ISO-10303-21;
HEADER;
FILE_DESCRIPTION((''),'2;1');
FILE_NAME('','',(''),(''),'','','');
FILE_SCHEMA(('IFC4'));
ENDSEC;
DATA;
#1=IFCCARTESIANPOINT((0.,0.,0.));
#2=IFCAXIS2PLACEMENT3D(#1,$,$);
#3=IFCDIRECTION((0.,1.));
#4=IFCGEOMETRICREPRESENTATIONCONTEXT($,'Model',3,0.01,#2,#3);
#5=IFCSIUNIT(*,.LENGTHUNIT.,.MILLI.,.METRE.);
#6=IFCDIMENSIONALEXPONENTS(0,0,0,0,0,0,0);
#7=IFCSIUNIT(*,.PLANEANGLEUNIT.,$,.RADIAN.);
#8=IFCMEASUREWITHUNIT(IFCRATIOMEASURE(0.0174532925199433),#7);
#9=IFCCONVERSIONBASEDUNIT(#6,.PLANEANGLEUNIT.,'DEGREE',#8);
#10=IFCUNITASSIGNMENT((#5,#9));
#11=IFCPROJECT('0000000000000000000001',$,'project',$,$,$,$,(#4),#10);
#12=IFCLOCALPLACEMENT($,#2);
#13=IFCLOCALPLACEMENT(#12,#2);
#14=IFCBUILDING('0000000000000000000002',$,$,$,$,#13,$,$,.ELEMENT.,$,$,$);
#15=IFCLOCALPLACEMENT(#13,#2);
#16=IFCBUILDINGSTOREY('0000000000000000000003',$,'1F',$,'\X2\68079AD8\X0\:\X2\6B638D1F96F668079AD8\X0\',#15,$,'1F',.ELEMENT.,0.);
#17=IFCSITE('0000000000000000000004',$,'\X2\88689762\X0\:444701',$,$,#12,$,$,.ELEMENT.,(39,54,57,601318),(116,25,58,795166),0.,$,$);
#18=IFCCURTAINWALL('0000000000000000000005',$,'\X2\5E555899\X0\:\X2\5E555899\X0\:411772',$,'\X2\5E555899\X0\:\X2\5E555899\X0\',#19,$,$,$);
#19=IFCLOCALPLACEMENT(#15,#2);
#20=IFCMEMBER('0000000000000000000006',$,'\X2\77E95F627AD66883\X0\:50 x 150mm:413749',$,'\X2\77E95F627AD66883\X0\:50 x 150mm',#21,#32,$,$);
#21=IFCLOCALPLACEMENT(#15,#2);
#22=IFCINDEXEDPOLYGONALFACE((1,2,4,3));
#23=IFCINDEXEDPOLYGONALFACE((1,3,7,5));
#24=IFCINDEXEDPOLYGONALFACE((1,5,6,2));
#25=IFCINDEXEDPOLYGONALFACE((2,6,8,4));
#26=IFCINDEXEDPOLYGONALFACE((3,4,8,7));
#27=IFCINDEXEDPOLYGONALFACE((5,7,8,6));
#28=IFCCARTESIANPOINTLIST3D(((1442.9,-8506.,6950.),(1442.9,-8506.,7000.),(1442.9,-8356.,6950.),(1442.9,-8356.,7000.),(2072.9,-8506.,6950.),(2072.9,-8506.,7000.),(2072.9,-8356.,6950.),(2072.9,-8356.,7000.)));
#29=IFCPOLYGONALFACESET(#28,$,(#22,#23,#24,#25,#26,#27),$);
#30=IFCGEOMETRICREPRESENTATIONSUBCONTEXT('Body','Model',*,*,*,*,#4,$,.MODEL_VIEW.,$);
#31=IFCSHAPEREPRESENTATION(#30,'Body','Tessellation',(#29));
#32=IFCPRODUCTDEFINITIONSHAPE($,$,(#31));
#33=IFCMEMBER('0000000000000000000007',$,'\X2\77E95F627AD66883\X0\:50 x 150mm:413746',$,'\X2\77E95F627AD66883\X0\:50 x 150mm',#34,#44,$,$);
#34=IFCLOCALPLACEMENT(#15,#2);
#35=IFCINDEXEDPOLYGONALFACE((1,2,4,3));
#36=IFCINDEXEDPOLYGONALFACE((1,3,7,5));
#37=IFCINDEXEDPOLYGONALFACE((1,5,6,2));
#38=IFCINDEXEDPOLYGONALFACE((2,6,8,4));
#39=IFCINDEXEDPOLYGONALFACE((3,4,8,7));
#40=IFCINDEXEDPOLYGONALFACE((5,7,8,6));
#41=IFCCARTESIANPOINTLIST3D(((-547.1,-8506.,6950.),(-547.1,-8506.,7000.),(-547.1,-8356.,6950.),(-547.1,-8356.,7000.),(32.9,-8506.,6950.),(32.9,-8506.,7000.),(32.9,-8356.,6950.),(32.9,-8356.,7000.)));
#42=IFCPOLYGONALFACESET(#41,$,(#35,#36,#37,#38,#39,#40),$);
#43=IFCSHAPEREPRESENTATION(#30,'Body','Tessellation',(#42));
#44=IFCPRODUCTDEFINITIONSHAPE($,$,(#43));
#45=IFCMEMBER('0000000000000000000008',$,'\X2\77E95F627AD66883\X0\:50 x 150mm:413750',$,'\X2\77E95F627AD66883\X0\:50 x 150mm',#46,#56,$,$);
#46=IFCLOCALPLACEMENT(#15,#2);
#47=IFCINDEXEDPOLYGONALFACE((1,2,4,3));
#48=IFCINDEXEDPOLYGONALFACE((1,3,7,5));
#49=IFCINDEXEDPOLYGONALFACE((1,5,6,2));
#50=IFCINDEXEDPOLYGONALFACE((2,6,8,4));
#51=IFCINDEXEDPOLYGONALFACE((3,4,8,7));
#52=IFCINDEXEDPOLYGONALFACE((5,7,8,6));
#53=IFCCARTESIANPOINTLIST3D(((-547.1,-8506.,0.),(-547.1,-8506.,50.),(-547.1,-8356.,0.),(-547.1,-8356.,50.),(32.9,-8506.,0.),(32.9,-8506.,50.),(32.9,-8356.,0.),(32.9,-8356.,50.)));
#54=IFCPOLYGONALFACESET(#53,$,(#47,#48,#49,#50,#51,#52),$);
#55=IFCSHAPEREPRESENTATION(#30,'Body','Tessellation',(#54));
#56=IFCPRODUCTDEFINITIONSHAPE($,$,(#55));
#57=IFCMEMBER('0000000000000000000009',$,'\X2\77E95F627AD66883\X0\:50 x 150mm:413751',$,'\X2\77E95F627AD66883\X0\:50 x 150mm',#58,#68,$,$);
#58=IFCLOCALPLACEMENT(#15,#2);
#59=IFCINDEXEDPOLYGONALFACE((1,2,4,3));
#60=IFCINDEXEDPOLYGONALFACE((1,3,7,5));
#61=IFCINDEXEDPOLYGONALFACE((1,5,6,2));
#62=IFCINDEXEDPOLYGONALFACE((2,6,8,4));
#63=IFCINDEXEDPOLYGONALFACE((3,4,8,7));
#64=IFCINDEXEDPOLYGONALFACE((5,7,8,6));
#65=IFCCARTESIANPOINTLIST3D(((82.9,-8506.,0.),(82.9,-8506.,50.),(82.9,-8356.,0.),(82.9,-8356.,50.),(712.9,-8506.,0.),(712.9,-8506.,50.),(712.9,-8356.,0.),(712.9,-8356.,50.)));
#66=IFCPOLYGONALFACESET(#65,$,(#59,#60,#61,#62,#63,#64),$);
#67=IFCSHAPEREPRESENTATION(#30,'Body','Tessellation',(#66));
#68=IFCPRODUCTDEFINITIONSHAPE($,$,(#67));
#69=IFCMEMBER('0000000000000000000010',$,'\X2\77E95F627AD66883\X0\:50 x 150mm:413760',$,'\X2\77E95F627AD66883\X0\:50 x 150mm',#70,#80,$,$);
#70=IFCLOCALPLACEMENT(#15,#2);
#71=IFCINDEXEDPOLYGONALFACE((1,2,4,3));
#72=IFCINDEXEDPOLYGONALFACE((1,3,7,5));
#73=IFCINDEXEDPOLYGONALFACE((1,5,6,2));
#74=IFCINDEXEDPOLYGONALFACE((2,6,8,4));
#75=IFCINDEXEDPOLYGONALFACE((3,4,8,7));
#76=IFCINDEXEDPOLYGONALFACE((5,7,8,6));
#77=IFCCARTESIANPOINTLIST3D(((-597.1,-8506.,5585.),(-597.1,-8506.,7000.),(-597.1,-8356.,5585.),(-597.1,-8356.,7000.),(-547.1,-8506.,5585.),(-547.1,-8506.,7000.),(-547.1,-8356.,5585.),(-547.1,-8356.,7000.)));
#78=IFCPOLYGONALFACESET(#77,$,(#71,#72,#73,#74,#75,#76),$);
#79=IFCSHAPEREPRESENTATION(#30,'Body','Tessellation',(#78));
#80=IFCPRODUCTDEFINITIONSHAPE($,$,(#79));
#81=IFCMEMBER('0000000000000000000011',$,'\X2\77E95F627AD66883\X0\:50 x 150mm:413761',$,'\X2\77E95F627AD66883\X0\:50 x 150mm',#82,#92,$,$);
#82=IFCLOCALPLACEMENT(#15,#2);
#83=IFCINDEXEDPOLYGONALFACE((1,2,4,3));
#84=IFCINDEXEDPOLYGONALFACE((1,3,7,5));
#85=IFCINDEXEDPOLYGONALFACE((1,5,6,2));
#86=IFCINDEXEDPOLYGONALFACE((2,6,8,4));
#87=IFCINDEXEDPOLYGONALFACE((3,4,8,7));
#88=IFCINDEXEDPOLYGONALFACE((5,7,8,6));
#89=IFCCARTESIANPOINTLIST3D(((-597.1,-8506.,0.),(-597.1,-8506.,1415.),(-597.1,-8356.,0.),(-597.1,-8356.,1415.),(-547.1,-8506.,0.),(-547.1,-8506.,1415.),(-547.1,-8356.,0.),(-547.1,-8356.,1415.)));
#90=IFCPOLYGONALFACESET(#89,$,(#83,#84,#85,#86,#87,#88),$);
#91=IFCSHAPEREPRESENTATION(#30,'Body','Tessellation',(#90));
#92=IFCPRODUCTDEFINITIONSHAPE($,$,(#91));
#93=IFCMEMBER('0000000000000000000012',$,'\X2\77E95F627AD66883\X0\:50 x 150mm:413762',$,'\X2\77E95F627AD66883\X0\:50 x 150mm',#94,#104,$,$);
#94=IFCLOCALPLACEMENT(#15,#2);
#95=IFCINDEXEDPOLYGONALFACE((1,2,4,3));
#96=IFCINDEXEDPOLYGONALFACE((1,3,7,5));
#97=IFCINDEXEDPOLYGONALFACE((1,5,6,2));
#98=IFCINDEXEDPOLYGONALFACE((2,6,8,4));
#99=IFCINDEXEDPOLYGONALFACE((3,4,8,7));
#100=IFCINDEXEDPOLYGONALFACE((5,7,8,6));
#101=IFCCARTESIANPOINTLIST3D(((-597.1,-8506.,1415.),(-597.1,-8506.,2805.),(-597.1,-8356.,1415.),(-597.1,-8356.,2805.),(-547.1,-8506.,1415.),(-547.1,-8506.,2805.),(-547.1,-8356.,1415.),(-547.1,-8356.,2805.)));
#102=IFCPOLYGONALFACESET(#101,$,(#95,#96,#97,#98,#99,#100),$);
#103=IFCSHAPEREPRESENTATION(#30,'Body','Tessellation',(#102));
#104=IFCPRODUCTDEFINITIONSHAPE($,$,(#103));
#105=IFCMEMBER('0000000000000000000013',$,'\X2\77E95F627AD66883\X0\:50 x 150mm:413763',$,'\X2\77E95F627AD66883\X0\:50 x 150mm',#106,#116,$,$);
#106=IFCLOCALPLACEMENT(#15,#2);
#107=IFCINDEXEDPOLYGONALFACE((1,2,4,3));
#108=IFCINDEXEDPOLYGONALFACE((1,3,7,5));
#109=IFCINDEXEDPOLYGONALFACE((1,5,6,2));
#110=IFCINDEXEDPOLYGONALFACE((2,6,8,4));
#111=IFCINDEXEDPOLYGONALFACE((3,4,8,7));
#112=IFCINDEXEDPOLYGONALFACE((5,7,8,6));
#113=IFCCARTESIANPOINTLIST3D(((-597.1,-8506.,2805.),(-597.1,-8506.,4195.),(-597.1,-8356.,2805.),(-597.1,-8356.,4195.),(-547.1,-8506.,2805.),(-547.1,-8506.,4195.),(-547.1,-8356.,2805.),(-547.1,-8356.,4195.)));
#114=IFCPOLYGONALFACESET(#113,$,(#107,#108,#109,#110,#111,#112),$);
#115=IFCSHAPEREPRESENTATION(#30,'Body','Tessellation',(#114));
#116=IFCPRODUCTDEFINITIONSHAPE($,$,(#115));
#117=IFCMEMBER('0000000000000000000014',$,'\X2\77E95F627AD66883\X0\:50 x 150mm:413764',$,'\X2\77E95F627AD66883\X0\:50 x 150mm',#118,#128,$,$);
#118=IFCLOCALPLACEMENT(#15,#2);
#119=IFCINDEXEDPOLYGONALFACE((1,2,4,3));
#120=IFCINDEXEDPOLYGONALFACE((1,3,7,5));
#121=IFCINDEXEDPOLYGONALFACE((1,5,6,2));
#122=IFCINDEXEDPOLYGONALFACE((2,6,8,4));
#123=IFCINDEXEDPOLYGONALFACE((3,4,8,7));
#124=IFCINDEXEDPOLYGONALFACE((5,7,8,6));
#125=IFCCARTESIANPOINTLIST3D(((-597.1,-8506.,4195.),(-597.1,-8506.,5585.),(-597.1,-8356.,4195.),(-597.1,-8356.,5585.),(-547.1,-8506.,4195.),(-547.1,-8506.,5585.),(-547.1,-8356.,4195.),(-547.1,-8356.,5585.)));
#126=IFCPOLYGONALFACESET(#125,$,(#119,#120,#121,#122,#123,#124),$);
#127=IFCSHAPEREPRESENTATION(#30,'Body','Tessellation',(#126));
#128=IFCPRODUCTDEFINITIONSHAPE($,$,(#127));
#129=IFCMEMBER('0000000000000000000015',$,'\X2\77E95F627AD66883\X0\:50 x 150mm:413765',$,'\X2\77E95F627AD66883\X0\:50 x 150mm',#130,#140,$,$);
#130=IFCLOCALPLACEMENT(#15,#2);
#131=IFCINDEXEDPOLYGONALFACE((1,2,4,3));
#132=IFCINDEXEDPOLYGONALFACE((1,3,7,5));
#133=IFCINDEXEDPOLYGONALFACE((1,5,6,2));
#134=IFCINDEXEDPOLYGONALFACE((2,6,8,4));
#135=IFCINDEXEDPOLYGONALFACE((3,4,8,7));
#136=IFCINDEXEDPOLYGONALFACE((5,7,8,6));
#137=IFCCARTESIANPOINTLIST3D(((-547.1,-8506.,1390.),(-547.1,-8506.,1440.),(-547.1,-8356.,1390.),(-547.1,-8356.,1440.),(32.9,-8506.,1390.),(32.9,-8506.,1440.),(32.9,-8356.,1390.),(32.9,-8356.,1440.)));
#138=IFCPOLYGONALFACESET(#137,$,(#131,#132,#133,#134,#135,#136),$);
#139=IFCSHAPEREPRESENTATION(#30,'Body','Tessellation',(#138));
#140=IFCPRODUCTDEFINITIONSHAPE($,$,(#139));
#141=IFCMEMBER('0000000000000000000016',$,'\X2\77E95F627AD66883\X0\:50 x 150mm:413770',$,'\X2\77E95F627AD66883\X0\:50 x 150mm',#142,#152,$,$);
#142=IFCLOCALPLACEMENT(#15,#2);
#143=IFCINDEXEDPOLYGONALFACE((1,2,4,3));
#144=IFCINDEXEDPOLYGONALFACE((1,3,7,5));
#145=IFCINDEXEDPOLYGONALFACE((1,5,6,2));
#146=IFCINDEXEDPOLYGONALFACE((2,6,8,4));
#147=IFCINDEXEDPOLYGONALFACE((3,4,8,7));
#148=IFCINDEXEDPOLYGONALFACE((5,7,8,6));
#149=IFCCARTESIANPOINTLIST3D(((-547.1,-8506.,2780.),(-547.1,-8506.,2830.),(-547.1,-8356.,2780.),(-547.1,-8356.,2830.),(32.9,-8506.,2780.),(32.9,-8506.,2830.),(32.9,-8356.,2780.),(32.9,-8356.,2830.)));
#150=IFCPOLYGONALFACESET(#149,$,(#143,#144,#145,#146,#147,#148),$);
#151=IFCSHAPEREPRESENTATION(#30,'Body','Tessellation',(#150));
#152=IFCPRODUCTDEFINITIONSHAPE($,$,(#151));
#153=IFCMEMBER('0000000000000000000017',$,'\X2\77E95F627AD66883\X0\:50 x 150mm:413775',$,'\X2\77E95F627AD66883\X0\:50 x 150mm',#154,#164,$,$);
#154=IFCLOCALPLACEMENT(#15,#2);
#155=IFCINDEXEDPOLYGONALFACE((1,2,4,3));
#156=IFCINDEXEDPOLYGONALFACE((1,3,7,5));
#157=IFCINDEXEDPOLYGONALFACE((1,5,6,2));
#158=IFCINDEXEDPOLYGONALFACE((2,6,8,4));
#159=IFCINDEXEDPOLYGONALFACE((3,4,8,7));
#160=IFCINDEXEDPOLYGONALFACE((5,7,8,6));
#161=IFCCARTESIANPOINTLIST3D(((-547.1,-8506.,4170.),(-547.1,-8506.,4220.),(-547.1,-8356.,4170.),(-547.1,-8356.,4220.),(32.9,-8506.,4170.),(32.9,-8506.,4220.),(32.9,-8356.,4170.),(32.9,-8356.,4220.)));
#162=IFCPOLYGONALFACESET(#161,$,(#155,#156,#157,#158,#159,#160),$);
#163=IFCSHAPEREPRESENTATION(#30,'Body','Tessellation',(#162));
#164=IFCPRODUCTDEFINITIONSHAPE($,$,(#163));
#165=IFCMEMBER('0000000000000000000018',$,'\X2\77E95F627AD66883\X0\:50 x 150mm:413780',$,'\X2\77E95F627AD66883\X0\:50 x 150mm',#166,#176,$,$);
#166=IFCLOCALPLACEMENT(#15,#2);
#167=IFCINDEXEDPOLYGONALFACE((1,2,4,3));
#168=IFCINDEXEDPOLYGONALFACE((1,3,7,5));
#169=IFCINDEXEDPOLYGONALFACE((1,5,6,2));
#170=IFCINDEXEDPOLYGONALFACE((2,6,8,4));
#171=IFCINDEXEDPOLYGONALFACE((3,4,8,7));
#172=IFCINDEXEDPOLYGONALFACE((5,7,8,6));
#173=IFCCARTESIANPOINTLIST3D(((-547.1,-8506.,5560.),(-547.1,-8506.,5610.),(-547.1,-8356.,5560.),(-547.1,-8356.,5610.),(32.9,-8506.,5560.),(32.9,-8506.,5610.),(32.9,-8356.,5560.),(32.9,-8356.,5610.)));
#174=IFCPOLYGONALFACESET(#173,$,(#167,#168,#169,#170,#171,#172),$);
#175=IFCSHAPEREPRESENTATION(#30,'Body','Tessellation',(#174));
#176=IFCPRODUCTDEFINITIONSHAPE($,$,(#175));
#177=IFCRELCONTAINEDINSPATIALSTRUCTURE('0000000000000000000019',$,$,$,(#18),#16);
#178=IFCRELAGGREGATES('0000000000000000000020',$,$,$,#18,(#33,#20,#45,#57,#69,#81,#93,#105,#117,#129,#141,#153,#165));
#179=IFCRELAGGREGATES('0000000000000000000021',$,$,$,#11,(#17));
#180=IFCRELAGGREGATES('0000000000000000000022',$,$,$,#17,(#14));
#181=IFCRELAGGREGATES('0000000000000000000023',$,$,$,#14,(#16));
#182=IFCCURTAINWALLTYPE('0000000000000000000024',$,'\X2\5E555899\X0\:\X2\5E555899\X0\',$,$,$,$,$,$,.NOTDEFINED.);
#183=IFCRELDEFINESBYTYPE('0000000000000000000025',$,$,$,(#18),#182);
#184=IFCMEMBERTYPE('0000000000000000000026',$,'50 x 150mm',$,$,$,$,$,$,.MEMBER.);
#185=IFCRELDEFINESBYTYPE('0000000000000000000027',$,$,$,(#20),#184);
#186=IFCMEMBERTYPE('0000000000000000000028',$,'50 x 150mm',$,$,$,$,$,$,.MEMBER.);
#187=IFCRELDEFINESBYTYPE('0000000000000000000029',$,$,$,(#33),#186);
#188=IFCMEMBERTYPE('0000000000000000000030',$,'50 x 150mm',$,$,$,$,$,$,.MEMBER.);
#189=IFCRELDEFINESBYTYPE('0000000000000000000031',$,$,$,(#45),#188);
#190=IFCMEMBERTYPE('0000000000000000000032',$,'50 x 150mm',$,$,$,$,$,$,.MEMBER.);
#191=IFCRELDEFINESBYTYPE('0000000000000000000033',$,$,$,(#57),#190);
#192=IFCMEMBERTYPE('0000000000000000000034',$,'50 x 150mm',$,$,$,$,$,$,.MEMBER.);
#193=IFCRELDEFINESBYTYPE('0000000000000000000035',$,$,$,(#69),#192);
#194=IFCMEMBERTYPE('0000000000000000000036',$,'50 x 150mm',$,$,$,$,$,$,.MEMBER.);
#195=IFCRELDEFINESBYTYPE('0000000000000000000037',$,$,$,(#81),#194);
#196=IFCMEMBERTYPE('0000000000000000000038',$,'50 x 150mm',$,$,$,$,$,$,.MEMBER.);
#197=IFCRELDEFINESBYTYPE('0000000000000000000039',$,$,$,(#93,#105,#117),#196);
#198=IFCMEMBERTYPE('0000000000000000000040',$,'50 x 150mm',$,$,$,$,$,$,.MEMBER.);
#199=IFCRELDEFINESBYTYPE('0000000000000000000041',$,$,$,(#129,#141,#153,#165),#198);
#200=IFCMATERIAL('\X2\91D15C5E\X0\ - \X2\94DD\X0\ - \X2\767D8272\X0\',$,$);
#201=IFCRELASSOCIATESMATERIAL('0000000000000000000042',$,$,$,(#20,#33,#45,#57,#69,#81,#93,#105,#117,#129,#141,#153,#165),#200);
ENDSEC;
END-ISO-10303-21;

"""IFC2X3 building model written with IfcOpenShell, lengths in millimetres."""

from ifc_helpers import new_model, entity, si_unit, converted_unit, direction, frame, origin, origin_2d_with_axis, place, context, subcontext, project, spatial, rectangle, extrude, source, transform, mapped, material, type_object, type_shapes, element, aggregate, save


model = new_model("IFC2X3")

# Units and contexts
model_context = context("Model", 3, precision=0.01, world=origin(), true_north=direction((0.0, 1.0)))
body_context = subcontext(model_context, "Body", "Model", "MODEL_VIEW")
ifc_project = project(units=[si_unit("LENGTHUNIT", "METRE", prefix="MILLI"), converted_unit("PLANEANGLEUNIT", "DEGREE", entity("IfcRatioMeasure", 0.0174532925199433), si_unit("PLANEANGLEUNIT", "RADIAN"), dimensions=[0, 0, 0, 0, 0, 0, 0])], contexts=[model_context])

# Site, building, storey
site_placement = place(None, origin())
site = spatial("IfcSite", under=ifc_project, at=site_placement, Name="表面:444701", CompositionType="ELEMENT", RefLatitude=(39, 54, 57, 601318), RefLongitude=(116, 25, 58, 795166), RefElevation=0.0)
building_placement = place(site_placement, origin())
building = spatial("IfcBuilding", under=site, at=building_placement, CompositionType="ELEMENT")
storey_placement = place(building_placement, origin())
storey = spatial("IfcBuildingStorey", under=building, at=storey_placement, Name="1F", ObjectType="标高:正负零标高", LongName="1F", CompositionType="ELEMENT", Elevation=0.0)

# Curtain wall, members
curtain_wall_type = type_object("IfcCurtainWallType", Name="幕墙:幕墙", PredefinedType="NOTDEFINED")
curtain_wall_placement = place(storey_placement, origin())
curtain_wall = element("IfcCurtainWall", 1, at=curtain_wall_placement, inside=storey, type_object=curtain_wall_type, Name="幕墙:幕墙:411772", ObjectType="幕墙:幕墙")
ifc_material_1 = material(Name="金属 - 铝 - 白色")
member_type_1 = type_object("IfcMemberType", Name="50 x 150mm", PredefinedType="MEMBER")
shared_shape_1 = source(origin(), body_context, "Body", "SweptSolid", [
    extrude(rectangle(XDim=150.0, YDim=50.0, at=origin_2d_with_axis()), frame((-25.0, 0.0, -630.0), z_axis=(0.0, 0.0, 1.0), x_axis=(0.0, -1.0, 0.0)), (0.0, 0.0, 1.0), 630.0),
])
type_shapes(member_type_1, [shared_shape_1])
member_1_placement = place(storey_placement, frame((2072.9, -8431.0, 7000.0), z_axis=(1.0, 0.0, 0.0), x_axis=(0.0, 0.0, 1.0)))
member_1 = element("IfcMember", 2, at=member_1_placement, type_object=member_type_1, material=ifc_material_1, Name="矩形竖梃:50 x 150mm:413749", ObjectType="矩形竖梃:50 x 150mm", context=body_context, shape_type="MappedRepresentation", body=[
    mapped(shared_shape_1, transform((0.0, 0.0, 0.0), scale=1.0)),
])
member_type_2 = type_object("IfcMemberType", Name="50 x 150mm", PredefinedType="MEMBER")
shared_shape_2 = source(origin(), body_context, "Body", "SweptSolid", [
    extrude(rectangle(XDim=150.0, YDim=50.0, at=origin_2d_with_axis()), frame((-25.0, 0.0, -580.0), z_axis=(0.0, 0.0, 1.0), x_axis=(0.0, -1.0, 0.0)), (0.0, 0.0, 1.0), 580.0),
])
type_shapes(member_type_2, [shared_shape_2])
member_2_placement = place(storey_placement, frame((32.9, -8431.0, 7000.0), z_axis=(1.0, 0.0, 0.0), x_axis=(0.0, 0.0, 1.0)))
member_2 = element("IfcMember", 3, at=member_2_placement, type_object=member_type_2, material=ifc_material_1, Name="矩形竖梃:50 x 150mm:413746", ObjectType="矩形竖梃:50 x 150mm", context=body_context, shape_type="MappedRepresentation", body=[
    mapped(shared_shape_2, transform((0.0, 0.0, 0.0), scale=1.0)),
])
member_type_3 = type_object("IfcMemberType", Name="50 x 150mm", PredefinedType="MEMBER")
shared_shape_3 = source(origin(), body_context, "Body", "SweptSolid", [
    extrude(rectangle(XDim=150.0, YDim=50.0, at=origin_2d_with_axis()), frame((-25.0, 0.0, -580.0), z_axis=(0.0, 0.0, 1.0), x_axis=(0.0, -1.0, 0.0)), (0.0, 0.0, 1.0), 580.0),
])
type_shapes(member_type_3, [shared_shape_3])
member_3_placement = place(storey_placement, frame((-547.1, -8431.0, 0.0), z_axis=(-1.0, 0.0, 0.0), x_axis=(0.0, 0.0, -1.0)))
member_3 = element("IfcMember", 4, at=member_3_placement, type_object=member_type_3, material=ifc_material_1, Name="矩形竖梃:50 x 150mm:413750", ObjectType="矩形竖梃:50 x 150mm", context=body_context, shape_type="MappedRepresentation", body=[
    mapped(shared_shape_3, transform((0.0, 0.0, 0.0), scale=1.0)),
])
member_type_4 = type_object("IfcMemberType", Name="50 x 150mm", PredefinedType="MEMBER")
shared_shape_4 = source(origin(), body_context, "Body", "SweptSolid", [
    extrude(rectangle(XDim=150.0, YDim=50.0, at=origin_2d_with_axis()), frame((-25.0, 0.0, -630.0), z_axis=(0.0, 0.0, 1.0), x_axis=(0.0, -1.0, 0.0)), (0.0, 0.0, 1.0), 630.0),
])
type_shapes(member_type_4, [shared_shape_4])
member_4_placement = place(storey_placement, frame((82.9, -8431.0, 0.0), z_axis=(-1.0, 0.0, 0.0), x_axis=(0.0, 0.0, -1.0)))
member_4 = element("IfcMember", 5, at=member_4_placement, type_object=member_type_4, material=ifc_material_1, Name="矩形竖梃:50 x 150mm:413751", ObjectType="矩形竖梃:50 x 150mm", context=body_context, shape_type="MappedRepresentation", body=[
    mapped(shared_shape_4, transform((0.0, 0.0, 0.0), scale=1.0)),
])
member_type_5 = type_object("IfcMemberType", Name="50 x 150mm", PredefinedType="MEMBER")
shared_shape_5 = source(origin(), body_context, "Body", "SweptSolid", [
    extrude(rectangle(XDim=150.0, YDim=50.0, at=origin_2d_with_axis()), frame((-25.0, 0.0, -1415.0), z_axis=(0.0, 0.0, 1.0), x_axis=(0.0, -1.0, 0.0)), (0.0, 0.0, 1.0), 1415.0),
])
type_shapes(member_type_5, [shared_shape_5])
member_5_placement = place(storey_placement, frame((-597.1, -8431.0, 7000.0), z_axis=(0.0, 0.0, 1.0), x_axis=(-1.0, 0.0, 0.0)))
member_5 = element("IfcMember", 6, at=member_5_placement, type_object=member_type_5, material=ifc_material_1, Name="矩形竖梃:50 x 150mm:413760", ObjectType="矩形竖梃:50 x 150mm", context=body_context, shape_type="MappedRepresentation", body=[
    mapped(shared_shape_5, transform((0.0, 0.0, 0.0), scale=1.0)),
])
member_type_6 = type_object("IfcMemberType", Name="50 x 150mm", PredefinedType="MEMBER")
shared_shape_6 = source(origin(), body_context, "Body", "SweptSolid", [
    extrude(rectangle(XDim=150.0, YDim=50.0, at=origin_2d_with_axis()), frame((-25.0, 0.0, -1415.0), z_axis=(0.0, 0.0, 1.0), x_axis=(0.0, -1.0, 0.0)), (0.0, 0.0, 1.0), 1415.0),
])
type_shapes(member_type_6, [shared_shape_6])
member_6_placement = place(storey_placement, frame((-597.1, -8431.0, 1415.0), z_axis=(0.0, 0.0, 1.0), x_axis=(-1.0, 0.0, 0.0)))
member_6 = element("IfcMember", 7, at=member_6_placement, type_object=member_type_6, material=ifc_material_1, Name="矩形竖梃:50 x 150mm:413761", ObjectType="矩形竖梃:50 x 150mm", context=body_context, shape_type="MappedRepresentation", body=[
    mapped(shared_shape_6, transform((0.0, 0.0, 0.0), scale=1.0)),
])
member_type_7 = type_object("IfcMemberType", Name="50 x 150mm", PredefinedType="MEMBER")
shared_shape_7 = source(origin(), body_context, "Body", "SweptSolid", [
    extrude(rectangle(XDim=150.0, YDim=50.0, at=origin_2d_with_axis()), frame((-25.0, 0.0, -1390.0), z_axis=(0.0, 0.0, 1.0), x_axis=(0.0, -1.0, 0.0)), (0.0, 0.0, 1.0), 1390.0),
])
type_shapes(member_type_7, [shared_shape_7])
member_7_placement = place(storey_placement, frame((-597.1, -8431.0, 2805.0), z_axis=(0.0, 0.0, 1.0), x_axis=(-1.0, 0.0, 0.0)))
member_7 = element("IfcMember", 8, at=member_7_placement, type_object=member_type_7, material=ifc_material_1, Name="矩形竖梃:50 x 150mm:413762", ObjectType="矩形竖梃:50 x 150mm", context=body_context, shape_type="MappedRepresentation", body=[
    mapped(shared_shape_7, transform((0.0, 0.0, 0.0), scale=1.0)),
])
member_8_placement = place(storey_placement, frame((-597.1, -8431.0, 4195.0), z_axis=(0.0, 0.0, 1.0), x_axis=(-1.0, 0.0, 0.0)))
member_8 = element("IfcMember", 9, at=member_8_placement, type_object=member_type_7, material=ifc_material_1, Name="矩形竖梃:50 x 150mm:413763", ObjectType="矩形竖梃:50 x 150mm", context=body_context, shape_type="MappedRepresentation", body=[
    mapped(shared_shape_7, transform((0.0, 0.0, 0.0), scale=1.0)),
])
member_9_placement = place(storey_placement, frame((-597.1, -8431.0, 5585.0), z_axis=(0.0, 0.0, 1.0), x_axis=(-1.0, 0.0, 0.0)))
member_9 = element("IfcMember", 10, at=member_9_placement, type_object=member_type_7, material=ifc_material_1, Name="矩形竖梃:50 x 150mm:413764", ObjectType="矩形竖梃:50 x 150mm", context=body_context, shape_type="MappedRepresentation", body=[
    mapped(shared_shape_7, transform((0.0, 0.0, 0.0), scale=1.0)),
])
member_type_8 = type_object("IfcMemberType", Name="50 x 150mm", PredefinedType="MEMBER")
shared_shape_8 = source(origin(), body_context, "Body", "SweptSolid", [
    extrude(rectangle(XDim=150.0, YDim=50.0, at=origin_2d_with_axis()), frame((0.0, 0.0, -580.0), z_axis=(0.0, 0.0, 1.0), x_axis=(0.0, -1.0, 0.0)), (0.0, 0.0, 1.0), 580.0),
])
type_shapes(member_type_8, [shared_shape_8])
member_10_placement = place(storey_placement, frame((32.9, -8431.0, 1415.0), z_axis=(1.0, 0.0, 0.0), x_axis=(0.0, 0.0, 1.0)))
member_10 = element("IfcMember", 11, at=member_10_placement, type_object=member_type_8, material=ifc_material_1, Name="矩形竖梃:50 x 150mm:413765", ObjectType="矩形竖梃:50 x 150mm", context=body_context, shape_type="MappedRepresentation", body=[
    mapped(shared_shape_8, transform((0.0, 0.0, 0.0), scale=1.0)),
])
member_11_placement = place(storey_placement, frame((32.9, -8431.0, 2805.0), z_axis=(1.0, 0.0, 0.0), x_axis=(0.0, 0.0, 1.0)))
member_11 = element("IfcMember", 12, at=member_11_placement, type_object=member_type_8, material=ifc_material_1, Name="矩形竖梃:50 x 150mm:413770", ObjectType="矩形竖梃:50 x 150mm", context=body_context, shape_type="MappedRepresentation", body=[
    mapped(shared_shape_8, transform((0.0, 0.0, 0.0), scale=1.0)),
])
member_12_placement = place(storey_placement, frame((32.9, -8431.0, 4195.0), z_axis=(1.0, 0.0, 0.0), x_axis=(0.0, 0.0, 1.0)))
member_12 = element("IfcMember", 13, at=member_12_placement, type_object=member_type_8, material=ifc_material_1, Name="矩形竖梃:50 x 150mm:413775", ObjectType="矩形竖梃:50 x 150mm", context=body_context, shape_type="MappedRepresentation", body=[
    mapped(shared_shape_8, transform((0.0, 0.0, 0.0), scale=1.0)),
])
member_13_placement = place(storey_placement, frame((32.9, -8431.0, 5585.0), z_axis=(1.0, 0.0, 0.0), x_axis=(0.0, 0.0, 1.0)))
member_13 = element("IfcMember", 14, at=member_13_placement, type_object=member_type_8, material=ifc_material_1, Name="矩形竖梃:50 x 150mm:413780", ObjectType="矩形竖梃:50 x 150mm", context=body_context, shape_type="MappedRepresentation", body=[
    mapped(shared_shape_8, transform((0.0, 0.0, 0.0), scale=1.0)),
])
aggregate(curtain_wall, [member_2, member_1, member_3, member_4, member_5, member_6, member_7, member_8, member_9, member_10, member_11, member_12, member_13])

save(model, "model.ifc")
